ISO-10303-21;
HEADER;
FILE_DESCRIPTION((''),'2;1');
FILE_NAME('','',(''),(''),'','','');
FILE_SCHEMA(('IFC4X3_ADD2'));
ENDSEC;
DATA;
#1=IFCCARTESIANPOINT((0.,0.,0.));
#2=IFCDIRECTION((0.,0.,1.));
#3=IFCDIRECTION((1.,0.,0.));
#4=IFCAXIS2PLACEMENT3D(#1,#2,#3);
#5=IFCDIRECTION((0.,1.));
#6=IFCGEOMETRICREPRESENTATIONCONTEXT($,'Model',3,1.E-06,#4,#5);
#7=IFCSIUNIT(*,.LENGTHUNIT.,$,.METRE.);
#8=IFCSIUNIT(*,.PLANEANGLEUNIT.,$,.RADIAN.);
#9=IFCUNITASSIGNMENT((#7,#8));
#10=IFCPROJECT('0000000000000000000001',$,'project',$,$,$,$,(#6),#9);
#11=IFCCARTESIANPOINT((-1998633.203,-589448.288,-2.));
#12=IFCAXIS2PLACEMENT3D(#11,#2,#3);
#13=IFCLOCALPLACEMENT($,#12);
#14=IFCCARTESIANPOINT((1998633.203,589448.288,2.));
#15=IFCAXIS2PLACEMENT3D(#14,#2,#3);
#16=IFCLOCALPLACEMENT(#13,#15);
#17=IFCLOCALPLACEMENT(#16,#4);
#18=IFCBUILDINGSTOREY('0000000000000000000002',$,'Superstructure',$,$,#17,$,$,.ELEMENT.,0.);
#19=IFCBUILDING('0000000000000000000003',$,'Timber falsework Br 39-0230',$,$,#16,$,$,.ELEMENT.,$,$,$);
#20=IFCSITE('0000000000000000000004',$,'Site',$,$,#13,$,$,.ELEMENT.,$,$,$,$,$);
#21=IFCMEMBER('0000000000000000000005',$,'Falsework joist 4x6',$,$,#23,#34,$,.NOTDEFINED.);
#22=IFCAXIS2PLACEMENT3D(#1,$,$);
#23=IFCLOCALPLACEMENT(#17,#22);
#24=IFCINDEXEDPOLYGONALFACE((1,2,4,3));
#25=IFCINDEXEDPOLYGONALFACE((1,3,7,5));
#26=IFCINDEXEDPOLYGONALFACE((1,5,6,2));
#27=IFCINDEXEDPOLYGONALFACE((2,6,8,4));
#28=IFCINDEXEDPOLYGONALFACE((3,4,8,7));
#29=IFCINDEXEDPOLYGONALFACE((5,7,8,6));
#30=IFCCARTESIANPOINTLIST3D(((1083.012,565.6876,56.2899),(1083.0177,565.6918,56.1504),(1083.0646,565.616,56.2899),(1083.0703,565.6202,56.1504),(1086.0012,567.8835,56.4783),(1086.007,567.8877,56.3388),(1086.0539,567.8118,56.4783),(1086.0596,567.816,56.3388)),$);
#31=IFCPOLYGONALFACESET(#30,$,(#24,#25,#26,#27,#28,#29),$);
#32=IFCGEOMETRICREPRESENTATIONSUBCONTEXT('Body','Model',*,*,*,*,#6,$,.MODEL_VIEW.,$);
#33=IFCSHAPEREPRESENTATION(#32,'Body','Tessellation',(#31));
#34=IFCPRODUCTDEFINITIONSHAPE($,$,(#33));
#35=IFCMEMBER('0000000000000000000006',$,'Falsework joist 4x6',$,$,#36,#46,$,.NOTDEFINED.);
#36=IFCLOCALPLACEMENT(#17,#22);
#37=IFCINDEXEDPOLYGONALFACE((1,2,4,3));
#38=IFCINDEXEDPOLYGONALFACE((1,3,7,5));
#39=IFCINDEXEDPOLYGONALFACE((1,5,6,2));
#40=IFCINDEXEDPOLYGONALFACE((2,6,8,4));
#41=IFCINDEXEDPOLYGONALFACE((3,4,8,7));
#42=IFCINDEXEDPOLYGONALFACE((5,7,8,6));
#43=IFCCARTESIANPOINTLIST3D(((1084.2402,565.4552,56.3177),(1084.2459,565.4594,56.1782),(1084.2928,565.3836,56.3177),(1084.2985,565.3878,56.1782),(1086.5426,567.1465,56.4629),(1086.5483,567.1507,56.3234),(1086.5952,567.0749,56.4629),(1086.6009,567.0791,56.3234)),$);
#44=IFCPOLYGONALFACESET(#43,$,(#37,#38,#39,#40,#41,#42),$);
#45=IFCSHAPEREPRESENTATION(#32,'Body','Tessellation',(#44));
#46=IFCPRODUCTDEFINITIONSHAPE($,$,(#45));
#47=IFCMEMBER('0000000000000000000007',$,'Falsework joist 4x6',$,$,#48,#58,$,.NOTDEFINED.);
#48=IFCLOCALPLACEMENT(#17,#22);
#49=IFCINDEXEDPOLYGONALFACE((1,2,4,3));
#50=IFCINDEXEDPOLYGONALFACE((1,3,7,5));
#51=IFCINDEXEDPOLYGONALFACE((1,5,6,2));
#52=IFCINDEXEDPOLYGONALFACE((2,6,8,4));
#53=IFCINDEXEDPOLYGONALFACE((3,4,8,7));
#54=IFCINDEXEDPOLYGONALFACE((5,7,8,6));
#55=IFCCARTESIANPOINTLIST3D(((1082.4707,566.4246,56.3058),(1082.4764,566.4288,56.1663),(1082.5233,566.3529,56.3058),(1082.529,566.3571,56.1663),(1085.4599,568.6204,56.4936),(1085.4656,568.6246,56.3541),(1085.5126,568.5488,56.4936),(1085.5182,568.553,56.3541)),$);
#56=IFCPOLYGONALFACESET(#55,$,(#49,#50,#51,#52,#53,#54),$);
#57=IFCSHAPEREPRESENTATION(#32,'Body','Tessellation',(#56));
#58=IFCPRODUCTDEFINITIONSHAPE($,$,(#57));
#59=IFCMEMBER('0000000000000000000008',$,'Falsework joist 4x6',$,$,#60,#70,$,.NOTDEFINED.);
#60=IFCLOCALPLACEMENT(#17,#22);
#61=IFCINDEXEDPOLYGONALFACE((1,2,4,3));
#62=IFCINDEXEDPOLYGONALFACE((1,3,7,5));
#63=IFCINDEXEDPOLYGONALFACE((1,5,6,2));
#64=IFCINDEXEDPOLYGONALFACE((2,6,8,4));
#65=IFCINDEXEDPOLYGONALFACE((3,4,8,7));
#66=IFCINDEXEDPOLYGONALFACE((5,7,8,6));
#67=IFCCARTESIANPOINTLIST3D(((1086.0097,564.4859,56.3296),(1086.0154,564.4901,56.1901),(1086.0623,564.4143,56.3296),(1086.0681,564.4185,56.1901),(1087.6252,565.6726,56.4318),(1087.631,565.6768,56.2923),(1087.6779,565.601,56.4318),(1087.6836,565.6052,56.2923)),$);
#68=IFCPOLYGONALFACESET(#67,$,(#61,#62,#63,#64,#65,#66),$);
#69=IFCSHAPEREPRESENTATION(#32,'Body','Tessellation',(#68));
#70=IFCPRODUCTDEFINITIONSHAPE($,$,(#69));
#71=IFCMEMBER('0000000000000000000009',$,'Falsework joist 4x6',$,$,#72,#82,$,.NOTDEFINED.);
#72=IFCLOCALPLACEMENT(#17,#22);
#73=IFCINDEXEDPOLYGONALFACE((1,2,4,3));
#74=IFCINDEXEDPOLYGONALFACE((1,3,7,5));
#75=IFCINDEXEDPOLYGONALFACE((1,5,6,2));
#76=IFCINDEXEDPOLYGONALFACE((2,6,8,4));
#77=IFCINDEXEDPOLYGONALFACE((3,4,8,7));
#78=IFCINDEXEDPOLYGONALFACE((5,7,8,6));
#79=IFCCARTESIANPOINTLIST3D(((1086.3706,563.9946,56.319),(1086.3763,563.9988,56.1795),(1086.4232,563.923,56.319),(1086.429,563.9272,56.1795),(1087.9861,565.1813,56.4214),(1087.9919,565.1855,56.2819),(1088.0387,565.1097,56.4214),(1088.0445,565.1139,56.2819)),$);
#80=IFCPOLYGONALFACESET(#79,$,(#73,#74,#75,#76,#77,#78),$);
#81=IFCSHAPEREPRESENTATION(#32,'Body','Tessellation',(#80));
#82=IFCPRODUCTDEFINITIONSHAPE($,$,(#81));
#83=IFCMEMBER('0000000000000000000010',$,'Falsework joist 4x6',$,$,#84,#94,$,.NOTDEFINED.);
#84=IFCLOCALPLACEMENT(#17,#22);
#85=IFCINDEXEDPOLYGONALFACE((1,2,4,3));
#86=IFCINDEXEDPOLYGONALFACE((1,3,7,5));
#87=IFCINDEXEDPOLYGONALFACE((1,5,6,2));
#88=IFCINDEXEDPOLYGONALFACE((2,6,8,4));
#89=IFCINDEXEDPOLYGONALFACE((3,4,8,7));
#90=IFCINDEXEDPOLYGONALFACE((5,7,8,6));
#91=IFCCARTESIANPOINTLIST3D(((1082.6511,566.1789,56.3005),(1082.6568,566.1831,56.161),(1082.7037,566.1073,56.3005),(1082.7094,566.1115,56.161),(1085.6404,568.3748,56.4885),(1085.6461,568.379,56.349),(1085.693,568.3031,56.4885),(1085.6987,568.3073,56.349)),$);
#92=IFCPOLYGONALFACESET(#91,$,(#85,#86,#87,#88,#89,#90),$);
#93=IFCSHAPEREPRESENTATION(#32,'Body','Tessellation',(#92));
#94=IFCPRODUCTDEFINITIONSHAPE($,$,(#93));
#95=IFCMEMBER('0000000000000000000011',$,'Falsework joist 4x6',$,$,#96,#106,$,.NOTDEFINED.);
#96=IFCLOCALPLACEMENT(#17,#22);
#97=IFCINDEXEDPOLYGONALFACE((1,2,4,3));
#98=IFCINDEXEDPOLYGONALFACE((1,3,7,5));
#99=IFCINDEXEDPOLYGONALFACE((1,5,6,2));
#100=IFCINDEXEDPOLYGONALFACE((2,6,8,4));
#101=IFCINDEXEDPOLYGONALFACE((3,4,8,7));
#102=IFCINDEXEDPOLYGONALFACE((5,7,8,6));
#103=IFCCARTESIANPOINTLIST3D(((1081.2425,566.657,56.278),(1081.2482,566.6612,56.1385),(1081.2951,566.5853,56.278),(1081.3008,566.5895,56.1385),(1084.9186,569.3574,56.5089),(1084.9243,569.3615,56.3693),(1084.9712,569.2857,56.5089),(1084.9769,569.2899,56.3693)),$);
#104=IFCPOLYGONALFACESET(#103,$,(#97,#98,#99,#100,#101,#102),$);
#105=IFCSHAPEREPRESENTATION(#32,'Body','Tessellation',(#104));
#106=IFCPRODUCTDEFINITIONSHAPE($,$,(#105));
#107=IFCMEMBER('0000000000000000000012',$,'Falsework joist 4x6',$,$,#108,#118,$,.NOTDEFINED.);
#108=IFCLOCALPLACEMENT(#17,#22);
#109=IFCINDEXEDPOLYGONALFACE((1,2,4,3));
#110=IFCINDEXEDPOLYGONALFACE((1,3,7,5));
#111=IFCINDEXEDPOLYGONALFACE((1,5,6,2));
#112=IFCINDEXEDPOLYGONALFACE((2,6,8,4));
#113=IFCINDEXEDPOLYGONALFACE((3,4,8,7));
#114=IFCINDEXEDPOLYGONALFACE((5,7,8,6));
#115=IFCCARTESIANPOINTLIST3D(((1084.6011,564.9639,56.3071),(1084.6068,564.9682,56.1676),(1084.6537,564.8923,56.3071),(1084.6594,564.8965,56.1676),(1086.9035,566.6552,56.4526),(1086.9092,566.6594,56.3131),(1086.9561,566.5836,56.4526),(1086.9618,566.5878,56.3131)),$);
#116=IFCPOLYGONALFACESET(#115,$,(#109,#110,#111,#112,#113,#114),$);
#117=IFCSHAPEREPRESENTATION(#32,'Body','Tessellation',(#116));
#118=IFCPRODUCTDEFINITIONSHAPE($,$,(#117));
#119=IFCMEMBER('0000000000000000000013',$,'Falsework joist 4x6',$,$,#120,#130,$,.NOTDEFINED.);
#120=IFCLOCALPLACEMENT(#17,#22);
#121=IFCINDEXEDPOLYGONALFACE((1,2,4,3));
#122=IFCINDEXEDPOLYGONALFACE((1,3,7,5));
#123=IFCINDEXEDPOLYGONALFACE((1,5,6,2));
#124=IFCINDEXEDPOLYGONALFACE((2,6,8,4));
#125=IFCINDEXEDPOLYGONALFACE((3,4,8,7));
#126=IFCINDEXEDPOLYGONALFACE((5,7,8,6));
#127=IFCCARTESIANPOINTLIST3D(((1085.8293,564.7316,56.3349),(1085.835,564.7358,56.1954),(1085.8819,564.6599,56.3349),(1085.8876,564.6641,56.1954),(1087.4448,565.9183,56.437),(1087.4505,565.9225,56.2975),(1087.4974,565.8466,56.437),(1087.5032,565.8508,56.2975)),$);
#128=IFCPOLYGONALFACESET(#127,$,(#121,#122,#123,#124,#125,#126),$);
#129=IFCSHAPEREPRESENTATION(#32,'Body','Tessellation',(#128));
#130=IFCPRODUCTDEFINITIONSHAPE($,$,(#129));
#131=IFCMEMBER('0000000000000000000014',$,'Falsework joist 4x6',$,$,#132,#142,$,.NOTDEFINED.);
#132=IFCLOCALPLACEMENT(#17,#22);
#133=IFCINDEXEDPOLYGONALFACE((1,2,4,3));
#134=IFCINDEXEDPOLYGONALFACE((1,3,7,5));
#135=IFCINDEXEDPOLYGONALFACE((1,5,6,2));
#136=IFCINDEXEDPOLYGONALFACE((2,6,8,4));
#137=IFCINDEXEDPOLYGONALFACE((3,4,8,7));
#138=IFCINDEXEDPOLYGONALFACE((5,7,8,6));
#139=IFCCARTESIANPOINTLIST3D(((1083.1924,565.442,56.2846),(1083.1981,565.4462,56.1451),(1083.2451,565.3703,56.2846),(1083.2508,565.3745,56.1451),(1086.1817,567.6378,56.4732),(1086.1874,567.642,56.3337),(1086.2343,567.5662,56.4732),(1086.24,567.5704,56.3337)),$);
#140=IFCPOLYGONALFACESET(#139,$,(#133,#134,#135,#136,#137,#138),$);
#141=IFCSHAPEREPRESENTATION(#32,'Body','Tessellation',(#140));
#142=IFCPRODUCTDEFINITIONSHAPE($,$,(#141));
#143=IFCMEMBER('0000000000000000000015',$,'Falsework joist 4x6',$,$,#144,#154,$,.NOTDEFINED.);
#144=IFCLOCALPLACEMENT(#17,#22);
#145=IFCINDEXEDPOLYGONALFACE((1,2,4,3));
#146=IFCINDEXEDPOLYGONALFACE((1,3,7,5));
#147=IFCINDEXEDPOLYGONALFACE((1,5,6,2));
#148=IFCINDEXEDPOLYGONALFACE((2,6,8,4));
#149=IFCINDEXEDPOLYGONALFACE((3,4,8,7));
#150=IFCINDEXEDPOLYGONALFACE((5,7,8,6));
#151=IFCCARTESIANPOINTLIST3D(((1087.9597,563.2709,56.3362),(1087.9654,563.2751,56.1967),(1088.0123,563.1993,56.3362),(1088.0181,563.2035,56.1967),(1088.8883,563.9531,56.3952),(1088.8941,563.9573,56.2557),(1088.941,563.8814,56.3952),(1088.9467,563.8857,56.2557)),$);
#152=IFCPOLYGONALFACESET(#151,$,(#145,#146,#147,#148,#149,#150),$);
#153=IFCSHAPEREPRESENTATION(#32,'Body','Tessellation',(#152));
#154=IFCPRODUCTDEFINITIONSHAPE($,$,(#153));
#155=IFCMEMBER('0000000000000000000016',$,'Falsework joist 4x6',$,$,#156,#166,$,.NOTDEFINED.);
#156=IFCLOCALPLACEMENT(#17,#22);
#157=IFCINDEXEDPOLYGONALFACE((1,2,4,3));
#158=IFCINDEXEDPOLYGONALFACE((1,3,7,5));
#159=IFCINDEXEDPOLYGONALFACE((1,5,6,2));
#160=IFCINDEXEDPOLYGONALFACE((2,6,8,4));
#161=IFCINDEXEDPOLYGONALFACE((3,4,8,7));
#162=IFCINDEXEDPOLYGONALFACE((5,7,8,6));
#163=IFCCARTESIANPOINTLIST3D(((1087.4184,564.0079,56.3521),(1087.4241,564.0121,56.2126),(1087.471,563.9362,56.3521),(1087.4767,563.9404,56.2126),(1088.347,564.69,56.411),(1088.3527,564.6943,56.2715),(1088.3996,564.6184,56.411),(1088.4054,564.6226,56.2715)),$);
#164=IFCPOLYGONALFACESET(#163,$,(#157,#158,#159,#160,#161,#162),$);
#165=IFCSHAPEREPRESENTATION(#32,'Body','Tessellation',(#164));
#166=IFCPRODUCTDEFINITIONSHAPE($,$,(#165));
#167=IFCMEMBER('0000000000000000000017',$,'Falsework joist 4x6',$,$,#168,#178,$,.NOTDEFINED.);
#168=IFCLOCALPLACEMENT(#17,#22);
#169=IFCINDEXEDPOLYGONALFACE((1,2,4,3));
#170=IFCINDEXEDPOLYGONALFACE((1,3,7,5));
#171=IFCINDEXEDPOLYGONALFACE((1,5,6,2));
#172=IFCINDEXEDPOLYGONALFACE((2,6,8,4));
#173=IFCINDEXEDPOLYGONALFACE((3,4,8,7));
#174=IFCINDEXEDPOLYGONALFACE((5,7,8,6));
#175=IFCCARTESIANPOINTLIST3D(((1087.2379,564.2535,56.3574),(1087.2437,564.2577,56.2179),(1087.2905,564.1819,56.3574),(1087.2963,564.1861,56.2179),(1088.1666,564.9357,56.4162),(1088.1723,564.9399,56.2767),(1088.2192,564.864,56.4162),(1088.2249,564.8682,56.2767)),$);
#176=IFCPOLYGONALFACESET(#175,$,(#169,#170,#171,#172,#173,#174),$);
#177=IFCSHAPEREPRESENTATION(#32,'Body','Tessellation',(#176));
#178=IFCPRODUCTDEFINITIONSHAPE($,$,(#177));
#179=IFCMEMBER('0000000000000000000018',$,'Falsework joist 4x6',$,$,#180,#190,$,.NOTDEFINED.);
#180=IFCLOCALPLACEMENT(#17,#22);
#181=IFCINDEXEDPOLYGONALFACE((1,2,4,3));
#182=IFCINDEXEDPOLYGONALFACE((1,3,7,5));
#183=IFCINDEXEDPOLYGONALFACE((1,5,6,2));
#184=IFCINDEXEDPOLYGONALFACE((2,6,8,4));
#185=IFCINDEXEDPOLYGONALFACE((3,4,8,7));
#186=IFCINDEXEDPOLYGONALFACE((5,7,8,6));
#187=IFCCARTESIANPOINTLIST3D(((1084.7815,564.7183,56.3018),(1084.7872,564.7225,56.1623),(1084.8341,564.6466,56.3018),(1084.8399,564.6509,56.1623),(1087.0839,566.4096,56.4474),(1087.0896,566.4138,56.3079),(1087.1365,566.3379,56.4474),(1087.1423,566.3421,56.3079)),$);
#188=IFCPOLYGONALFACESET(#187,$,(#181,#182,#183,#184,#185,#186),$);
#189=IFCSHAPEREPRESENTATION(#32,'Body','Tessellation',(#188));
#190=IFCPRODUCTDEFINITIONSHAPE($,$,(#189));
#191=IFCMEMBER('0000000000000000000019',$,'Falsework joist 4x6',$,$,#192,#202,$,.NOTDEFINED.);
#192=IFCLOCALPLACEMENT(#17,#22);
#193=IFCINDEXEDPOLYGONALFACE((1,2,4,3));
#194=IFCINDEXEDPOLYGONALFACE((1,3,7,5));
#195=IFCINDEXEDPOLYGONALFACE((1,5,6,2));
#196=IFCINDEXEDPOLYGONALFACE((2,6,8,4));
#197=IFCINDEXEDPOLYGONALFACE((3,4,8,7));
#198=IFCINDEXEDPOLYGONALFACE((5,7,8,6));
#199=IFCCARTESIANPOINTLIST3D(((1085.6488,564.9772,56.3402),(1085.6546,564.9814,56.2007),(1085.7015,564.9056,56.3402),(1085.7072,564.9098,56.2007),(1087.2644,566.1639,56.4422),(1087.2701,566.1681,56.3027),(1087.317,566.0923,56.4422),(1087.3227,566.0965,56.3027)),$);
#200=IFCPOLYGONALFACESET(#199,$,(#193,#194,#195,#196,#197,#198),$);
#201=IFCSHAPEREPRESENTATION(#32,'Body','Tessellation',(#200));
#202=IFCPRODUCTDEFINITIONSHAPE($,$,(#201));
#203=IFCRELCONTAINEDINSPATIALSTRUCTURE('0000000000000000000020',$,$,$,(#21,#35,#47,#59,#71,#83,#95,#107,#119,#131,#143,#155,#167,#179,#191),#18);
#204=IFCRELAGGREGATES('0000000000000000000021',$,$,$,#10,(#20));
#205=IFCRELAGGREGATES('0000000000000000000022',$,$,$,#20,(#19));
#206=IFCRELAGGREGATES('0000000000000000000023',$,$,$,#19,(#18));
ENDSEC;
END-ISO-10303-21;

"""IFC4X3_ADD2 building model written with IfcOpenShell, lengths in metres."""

from ifc_helpers import new_model, si_unit, direction, frame, frame_2d, origin, origin_with_axes, place, context, subcontext, project, spatial, rectangle, extrude, element, save


model = new_model("IFC4X3_ADD2")

# Units and contexts
model_context = context("Model", 3, precision=1e-06, world=origin_with_axes(), true_north=direction((0.0, 1.0)))
body_context = subcontext(model_context, "Body", "Model", "MODEL_VIEW")
ifc_project = project(units=[si_unit("LENGTHUNIT", "METRE"), si_unit("PLANEANGLEUNIT", "RADIAN")], contexts=[model_context])

# Site, building, storey
site_placement = place(None, frame((-1998633.203, -589448.288, -2.0), z_axis=(0.0, 0.0, 1.0), x_axis=(1.0, 0.0, 0.0)))
site = spatial("IfcSite", under=ifc_project, at=site_placement, Name="Site", CompositionType="ELEMENT")
building_placement = place(site_placement, frame((1998633.203, 589448.288, 2.0), z_axis=(0.0, 0.0, 1.0), x_axis=(1.0, 0.0, 0.0)))
building = spatial("IfcBuilding", under=site, at=building_placement, Name="Timber falsework Br 39-0230", CompositionType="ELEMENT")
storey_placement = place(building_placement, origin_with_axes())
storey = spatial("IfcBuildingStorey", under=building, at=storey_placement, Name="Superstructure", CompositionType="ELEMENT", Elevation=0.0)

# Members
member_1_placement = place(storey_placement, frame((1083.044, 565.656, 56.1504), z_axis=(0.804891, 0.591251, 0.050729), x_axis=(-0.592013, 0.805928, 0.0)))
element("IfcMember", 1, at=member_1_placement, inside=storey, Name="Falsework joist 4x6", PredefinedType="NOTDEFINED", context=body_context, shape_type="SweptSolid", body=[
    extrude(rectangle(XDim=0.0889, YDim=0.1397, at=frame_2d((0.0, 0.0698))), origin(), (0.0, 0.0, 1.0), 3.7139),
])
member_2_placement = place(storey_placement, frame((1084.2722, 565.4236, 56.1782), z_axis=(0.80489, 0.59125, 0.050754), x_axis=(-0.592013, 0.805928, 0.0)))
element("IfcMember", 2, at=member_2_placement, inside=storey, Name="Falsework joist 4x6", PredefinedType="NOTDEFINED", context=body_context, shape_type="SweptSolid", body=[
    extrude(rectangle(XDim=0.0889, YDim=0.1397, at=frame_2d((0.0, 0.0698))), origin(), (0.0, 0.0, 1.0), 2.8605),
])
member_3_placement = place(storey_placement, frame((1082.5027, 566.3929, 56.1663), z_axis=(0.804897, 0.591256, 0.050573), x_axis=(-0.592013, 0.805928, 0.0)))
element("IfcMember", 3, at=member_3_placement, inside=storey, Name="Falsework joist 4x6", PredefinedType="NOTDEFINED", context=body_context, shape_type="SweptSolid", body=[
    extrude(rectangle(XDim=0.0889, YDim=0.1397, at=frame_2d((0.0, 0.0698))), origin(), (0.0, 0.0, 1.0), 3.7138),
])
member_4_placement = place(storey_placement, frame((1086.0418, 564.4543, 56.1901), z_axis=(0.804882, 0.591245, 0.050935), x_axis=(-0.592013, 0.805928, 0.0)))
element("IfcMember", 4, at=member_4_placement, inside=storey, Name="Falsework joist 4x6", PredefinedType="NOTDEFINED", context=body_context, shape_type="SweptSolid", body=[
    extrude(rectangle(XDim=0.0889, YDim=0.1397, at=frame_2d((0.0, 0.0698))), origin(), (0.0, 0.0, 1.0), 2.0072),
])
member_5_placement = place(storey_placement, frame((1086.4027, 563.963, 56.1795), z_axis=(0.804878, 0.591242, 0.051039), x_axis=(-0.592013, 0.805928, 0.0)))
element("IfcMember", 5, at=member_5_placement, inside=storey, Name="Falsework joist 4x6", PredefinedType="NOTDEFINED", context=body_context, shape_type="SweptSolid", body=[
    extrude(rectangle(XDim=0.0889, YDim=0.1397, at=frame_2d((0.0, 0.0698))), origin(), (0.0, 0.0, 1.0), 2.0072),
])
member_6_placement = place(storey_placement, frame((1082.6831, 566.1473, 56.161), z_axis=(0.804895, 0.591254, 0.050625), x_axis=(-0.592013, 0.805928, 0.0)))
element("IfcMember", 6, at=member_6_placement, inside=storey, Name="Falsework joist 4x6", PredefinedType="NOTDEFINED", context=body_context, shape_type="SweptSolid", body=[
    extrude(rectangle(XDim=0.0889, YDim=0.1397, at=frame_2d((0.0, 0.0698))), origin(), (0.0, 0.0, 1.0), 3.7139),
])
member_7_placement = place(storey_placement, frame((1081.2745, 566.6253, 56.1385), z_axis=(0.804898, 0.591256, 0.050548), x_axis=(-0.592013, 0.805928, 0.0)))
element("IfcMember", 7, at=member_7_placement, inside=storey, Name="Falsework joist 4x6", PredefinedType="NOTDEFINED", context=body_context, shape_type="SweptSolid", body=[
    extrude(rectangle(XDim=0.0889, YDim=0.1397, at=frame_2d((0.0, 0.0698))), origin(), (0.0, 0.0, 1.0), 4.5672),
])
member_8_placement = place(storey_placement, frame((1084.6331, 564.9323, 56.1676), z_axis=(0.804885, 0.591247, 0.050858), x_axis=(-0.592013, 0.805928, 0.0)))
element("IfcMember", 8, at=member_8_placement, inside=storey, Name="Falsework joist 4x6", PredefinedType="NOTDEFINED", context=body_context, shape_type="SweptSolid", body=[
    extrude(rectangle(XDim=0.0889, YDim=0.1397, at=frame_2d((0.0, 0.0698))), origin(), (0.0, 0.0, 1.0), 2.8605),
])
member_9_placement = place(storey_placement, frame((1085.8613, 564.6999, 56.1954), z_axis=(0.804884, 0.591246, 0.050883), x_axis=(-0.592013, 0.805928, 0.0)))
element("IfcMember", 9, at=member_9_placement, inside=storey, Name="Falsework joist 4x6", PredefinedType="NOTDEFINED", context=body_context, shape_type="SweptSolid", body=[
    extrude(rectangle(XDim=0.0889, YDim=0.1397, at=frame_2d((0.0, 0.0698))), origin(), (0.0, 0.0, 1.0), 2.0071),
])
member_10_placement = place(storey_placement, frame((1083.2245, 565.4104, 56.1451), z_axis=(0.804889, 0.591249, 0.05078), x_axis=(-0.592013, 0.805928, 0.0)))
element("IfcMember", 10, at=member_10_placement, inside=storey, Name="Falsework joist 4x6", PredefinedType="NOTDEFINED", context=body_context, shape_type="SweptSolid", body=[
    extrude(rectangle(XDim=0.0889, YDim=0.1397, at=frame_2d((0.0, 0.0698))), origin(), (0.0, 0.0, 1.0), 3.7139),
])
member_11_placement = place(storey_placement, frame((1087.9918, 563.2393, 56.1967), z_axis=(0.804873, 0.591238, 0.051168), x_axis=(-0.592013, 0.805928, 0.0)))
element("IfcMember", 11, at=member_11_placement, inside=storey, Name="Falsework joist 4x6", PredefinedType="NOTDEFINED", context=body_context, shape_type="SweptSolid", body=[
    extrude(rectangle(XDim=0.0889, YDim=0.1397, at=frame_2d((0.0, 0.0698))), origin(), (0.0, 0.0, 1.0), 1.1538),
])
member_12_placement = place(storey_placement, frame((1087.4504, 563.9763, 56.2126), z_axis=(0.804879, 0.591242, 0.051012), x_axis=(-0.592013, 0.805928, 0.0)))
element("IfcMember", 12, at=member_12_placement, inside=storey, Name="Falsework joist 4x6", PredefinedType="NOTDEFINED", context=body_context, shape_type="SweptSolid", body=[
    extrude(rectangle(XDim=0.0889, YDim=0.1397, at=frame_2d((0.0, 0.0698))), origin(), (0.0, 0.0, 1.0), 1.1538),
])
member_13_placement = place(storey_placement, frame((1087.27, 564.2219, 56.2179), z_axis=(0.804881, 0.591244, 0.05096), x_axis=(-0.592013, 0.805928, 0.0)))
element("IfcMember", 13, at=member_13_placement, inside=storey, Name="Falsework joist 4x6", PredefinedType="NOTDEFINED", context=body_context, shape_type="SweptSolid", body=[
    extrude(rectangle(XDim=0.0889, YDim=0.1397, at=frame_2d((0.0, 0.0698))), origin(), (0.0, 0.0, 1.0), 1.1538),
])
member_14_placement = place(storey_placement, frame((1084.8136, 564.6867, 56.1623), z_axis=(0.804883, 0.591245, 0.05091), x_axis=(-0.592013, 0.805928, 0.0)))
element("IfcMember", 14, at=member_14_placement, inside=storey, Name="Falsework joist 4x6", PredefinedType="NOTDEFINED", context=body_context, shape_type="SweptSolid", body=[
    extrude(rectangle(XDim=0.0889, YDim=0.1397, at=frame_2d((0.0, 0.0698))), origin(), (0.0, 0.0, 1.0), 2.8605),
])
member_15_placement = place(storey_placement, frame((1085.6809, 564.9456, 56.2007), z_axis=(0.804886, 0.591248, 0.050831), x_axis=(-0.592013, 0.805928, 0.0)))
element("IfcMember", 15, at=member_15_placement, inside=storey, Name="Falsework joist 4x6", PredefinedType="NOTDEFINED", context=body_context, shape_type="SweptSolid", body=[
    extrude(rectangle(XDim=0.0889, YDim=0.1397, at=frame_2d((0.0, 0.0698))), origin(), (0.0, 0.0, 1.0), 2.0071),
])

save(model, "model.ifc")
